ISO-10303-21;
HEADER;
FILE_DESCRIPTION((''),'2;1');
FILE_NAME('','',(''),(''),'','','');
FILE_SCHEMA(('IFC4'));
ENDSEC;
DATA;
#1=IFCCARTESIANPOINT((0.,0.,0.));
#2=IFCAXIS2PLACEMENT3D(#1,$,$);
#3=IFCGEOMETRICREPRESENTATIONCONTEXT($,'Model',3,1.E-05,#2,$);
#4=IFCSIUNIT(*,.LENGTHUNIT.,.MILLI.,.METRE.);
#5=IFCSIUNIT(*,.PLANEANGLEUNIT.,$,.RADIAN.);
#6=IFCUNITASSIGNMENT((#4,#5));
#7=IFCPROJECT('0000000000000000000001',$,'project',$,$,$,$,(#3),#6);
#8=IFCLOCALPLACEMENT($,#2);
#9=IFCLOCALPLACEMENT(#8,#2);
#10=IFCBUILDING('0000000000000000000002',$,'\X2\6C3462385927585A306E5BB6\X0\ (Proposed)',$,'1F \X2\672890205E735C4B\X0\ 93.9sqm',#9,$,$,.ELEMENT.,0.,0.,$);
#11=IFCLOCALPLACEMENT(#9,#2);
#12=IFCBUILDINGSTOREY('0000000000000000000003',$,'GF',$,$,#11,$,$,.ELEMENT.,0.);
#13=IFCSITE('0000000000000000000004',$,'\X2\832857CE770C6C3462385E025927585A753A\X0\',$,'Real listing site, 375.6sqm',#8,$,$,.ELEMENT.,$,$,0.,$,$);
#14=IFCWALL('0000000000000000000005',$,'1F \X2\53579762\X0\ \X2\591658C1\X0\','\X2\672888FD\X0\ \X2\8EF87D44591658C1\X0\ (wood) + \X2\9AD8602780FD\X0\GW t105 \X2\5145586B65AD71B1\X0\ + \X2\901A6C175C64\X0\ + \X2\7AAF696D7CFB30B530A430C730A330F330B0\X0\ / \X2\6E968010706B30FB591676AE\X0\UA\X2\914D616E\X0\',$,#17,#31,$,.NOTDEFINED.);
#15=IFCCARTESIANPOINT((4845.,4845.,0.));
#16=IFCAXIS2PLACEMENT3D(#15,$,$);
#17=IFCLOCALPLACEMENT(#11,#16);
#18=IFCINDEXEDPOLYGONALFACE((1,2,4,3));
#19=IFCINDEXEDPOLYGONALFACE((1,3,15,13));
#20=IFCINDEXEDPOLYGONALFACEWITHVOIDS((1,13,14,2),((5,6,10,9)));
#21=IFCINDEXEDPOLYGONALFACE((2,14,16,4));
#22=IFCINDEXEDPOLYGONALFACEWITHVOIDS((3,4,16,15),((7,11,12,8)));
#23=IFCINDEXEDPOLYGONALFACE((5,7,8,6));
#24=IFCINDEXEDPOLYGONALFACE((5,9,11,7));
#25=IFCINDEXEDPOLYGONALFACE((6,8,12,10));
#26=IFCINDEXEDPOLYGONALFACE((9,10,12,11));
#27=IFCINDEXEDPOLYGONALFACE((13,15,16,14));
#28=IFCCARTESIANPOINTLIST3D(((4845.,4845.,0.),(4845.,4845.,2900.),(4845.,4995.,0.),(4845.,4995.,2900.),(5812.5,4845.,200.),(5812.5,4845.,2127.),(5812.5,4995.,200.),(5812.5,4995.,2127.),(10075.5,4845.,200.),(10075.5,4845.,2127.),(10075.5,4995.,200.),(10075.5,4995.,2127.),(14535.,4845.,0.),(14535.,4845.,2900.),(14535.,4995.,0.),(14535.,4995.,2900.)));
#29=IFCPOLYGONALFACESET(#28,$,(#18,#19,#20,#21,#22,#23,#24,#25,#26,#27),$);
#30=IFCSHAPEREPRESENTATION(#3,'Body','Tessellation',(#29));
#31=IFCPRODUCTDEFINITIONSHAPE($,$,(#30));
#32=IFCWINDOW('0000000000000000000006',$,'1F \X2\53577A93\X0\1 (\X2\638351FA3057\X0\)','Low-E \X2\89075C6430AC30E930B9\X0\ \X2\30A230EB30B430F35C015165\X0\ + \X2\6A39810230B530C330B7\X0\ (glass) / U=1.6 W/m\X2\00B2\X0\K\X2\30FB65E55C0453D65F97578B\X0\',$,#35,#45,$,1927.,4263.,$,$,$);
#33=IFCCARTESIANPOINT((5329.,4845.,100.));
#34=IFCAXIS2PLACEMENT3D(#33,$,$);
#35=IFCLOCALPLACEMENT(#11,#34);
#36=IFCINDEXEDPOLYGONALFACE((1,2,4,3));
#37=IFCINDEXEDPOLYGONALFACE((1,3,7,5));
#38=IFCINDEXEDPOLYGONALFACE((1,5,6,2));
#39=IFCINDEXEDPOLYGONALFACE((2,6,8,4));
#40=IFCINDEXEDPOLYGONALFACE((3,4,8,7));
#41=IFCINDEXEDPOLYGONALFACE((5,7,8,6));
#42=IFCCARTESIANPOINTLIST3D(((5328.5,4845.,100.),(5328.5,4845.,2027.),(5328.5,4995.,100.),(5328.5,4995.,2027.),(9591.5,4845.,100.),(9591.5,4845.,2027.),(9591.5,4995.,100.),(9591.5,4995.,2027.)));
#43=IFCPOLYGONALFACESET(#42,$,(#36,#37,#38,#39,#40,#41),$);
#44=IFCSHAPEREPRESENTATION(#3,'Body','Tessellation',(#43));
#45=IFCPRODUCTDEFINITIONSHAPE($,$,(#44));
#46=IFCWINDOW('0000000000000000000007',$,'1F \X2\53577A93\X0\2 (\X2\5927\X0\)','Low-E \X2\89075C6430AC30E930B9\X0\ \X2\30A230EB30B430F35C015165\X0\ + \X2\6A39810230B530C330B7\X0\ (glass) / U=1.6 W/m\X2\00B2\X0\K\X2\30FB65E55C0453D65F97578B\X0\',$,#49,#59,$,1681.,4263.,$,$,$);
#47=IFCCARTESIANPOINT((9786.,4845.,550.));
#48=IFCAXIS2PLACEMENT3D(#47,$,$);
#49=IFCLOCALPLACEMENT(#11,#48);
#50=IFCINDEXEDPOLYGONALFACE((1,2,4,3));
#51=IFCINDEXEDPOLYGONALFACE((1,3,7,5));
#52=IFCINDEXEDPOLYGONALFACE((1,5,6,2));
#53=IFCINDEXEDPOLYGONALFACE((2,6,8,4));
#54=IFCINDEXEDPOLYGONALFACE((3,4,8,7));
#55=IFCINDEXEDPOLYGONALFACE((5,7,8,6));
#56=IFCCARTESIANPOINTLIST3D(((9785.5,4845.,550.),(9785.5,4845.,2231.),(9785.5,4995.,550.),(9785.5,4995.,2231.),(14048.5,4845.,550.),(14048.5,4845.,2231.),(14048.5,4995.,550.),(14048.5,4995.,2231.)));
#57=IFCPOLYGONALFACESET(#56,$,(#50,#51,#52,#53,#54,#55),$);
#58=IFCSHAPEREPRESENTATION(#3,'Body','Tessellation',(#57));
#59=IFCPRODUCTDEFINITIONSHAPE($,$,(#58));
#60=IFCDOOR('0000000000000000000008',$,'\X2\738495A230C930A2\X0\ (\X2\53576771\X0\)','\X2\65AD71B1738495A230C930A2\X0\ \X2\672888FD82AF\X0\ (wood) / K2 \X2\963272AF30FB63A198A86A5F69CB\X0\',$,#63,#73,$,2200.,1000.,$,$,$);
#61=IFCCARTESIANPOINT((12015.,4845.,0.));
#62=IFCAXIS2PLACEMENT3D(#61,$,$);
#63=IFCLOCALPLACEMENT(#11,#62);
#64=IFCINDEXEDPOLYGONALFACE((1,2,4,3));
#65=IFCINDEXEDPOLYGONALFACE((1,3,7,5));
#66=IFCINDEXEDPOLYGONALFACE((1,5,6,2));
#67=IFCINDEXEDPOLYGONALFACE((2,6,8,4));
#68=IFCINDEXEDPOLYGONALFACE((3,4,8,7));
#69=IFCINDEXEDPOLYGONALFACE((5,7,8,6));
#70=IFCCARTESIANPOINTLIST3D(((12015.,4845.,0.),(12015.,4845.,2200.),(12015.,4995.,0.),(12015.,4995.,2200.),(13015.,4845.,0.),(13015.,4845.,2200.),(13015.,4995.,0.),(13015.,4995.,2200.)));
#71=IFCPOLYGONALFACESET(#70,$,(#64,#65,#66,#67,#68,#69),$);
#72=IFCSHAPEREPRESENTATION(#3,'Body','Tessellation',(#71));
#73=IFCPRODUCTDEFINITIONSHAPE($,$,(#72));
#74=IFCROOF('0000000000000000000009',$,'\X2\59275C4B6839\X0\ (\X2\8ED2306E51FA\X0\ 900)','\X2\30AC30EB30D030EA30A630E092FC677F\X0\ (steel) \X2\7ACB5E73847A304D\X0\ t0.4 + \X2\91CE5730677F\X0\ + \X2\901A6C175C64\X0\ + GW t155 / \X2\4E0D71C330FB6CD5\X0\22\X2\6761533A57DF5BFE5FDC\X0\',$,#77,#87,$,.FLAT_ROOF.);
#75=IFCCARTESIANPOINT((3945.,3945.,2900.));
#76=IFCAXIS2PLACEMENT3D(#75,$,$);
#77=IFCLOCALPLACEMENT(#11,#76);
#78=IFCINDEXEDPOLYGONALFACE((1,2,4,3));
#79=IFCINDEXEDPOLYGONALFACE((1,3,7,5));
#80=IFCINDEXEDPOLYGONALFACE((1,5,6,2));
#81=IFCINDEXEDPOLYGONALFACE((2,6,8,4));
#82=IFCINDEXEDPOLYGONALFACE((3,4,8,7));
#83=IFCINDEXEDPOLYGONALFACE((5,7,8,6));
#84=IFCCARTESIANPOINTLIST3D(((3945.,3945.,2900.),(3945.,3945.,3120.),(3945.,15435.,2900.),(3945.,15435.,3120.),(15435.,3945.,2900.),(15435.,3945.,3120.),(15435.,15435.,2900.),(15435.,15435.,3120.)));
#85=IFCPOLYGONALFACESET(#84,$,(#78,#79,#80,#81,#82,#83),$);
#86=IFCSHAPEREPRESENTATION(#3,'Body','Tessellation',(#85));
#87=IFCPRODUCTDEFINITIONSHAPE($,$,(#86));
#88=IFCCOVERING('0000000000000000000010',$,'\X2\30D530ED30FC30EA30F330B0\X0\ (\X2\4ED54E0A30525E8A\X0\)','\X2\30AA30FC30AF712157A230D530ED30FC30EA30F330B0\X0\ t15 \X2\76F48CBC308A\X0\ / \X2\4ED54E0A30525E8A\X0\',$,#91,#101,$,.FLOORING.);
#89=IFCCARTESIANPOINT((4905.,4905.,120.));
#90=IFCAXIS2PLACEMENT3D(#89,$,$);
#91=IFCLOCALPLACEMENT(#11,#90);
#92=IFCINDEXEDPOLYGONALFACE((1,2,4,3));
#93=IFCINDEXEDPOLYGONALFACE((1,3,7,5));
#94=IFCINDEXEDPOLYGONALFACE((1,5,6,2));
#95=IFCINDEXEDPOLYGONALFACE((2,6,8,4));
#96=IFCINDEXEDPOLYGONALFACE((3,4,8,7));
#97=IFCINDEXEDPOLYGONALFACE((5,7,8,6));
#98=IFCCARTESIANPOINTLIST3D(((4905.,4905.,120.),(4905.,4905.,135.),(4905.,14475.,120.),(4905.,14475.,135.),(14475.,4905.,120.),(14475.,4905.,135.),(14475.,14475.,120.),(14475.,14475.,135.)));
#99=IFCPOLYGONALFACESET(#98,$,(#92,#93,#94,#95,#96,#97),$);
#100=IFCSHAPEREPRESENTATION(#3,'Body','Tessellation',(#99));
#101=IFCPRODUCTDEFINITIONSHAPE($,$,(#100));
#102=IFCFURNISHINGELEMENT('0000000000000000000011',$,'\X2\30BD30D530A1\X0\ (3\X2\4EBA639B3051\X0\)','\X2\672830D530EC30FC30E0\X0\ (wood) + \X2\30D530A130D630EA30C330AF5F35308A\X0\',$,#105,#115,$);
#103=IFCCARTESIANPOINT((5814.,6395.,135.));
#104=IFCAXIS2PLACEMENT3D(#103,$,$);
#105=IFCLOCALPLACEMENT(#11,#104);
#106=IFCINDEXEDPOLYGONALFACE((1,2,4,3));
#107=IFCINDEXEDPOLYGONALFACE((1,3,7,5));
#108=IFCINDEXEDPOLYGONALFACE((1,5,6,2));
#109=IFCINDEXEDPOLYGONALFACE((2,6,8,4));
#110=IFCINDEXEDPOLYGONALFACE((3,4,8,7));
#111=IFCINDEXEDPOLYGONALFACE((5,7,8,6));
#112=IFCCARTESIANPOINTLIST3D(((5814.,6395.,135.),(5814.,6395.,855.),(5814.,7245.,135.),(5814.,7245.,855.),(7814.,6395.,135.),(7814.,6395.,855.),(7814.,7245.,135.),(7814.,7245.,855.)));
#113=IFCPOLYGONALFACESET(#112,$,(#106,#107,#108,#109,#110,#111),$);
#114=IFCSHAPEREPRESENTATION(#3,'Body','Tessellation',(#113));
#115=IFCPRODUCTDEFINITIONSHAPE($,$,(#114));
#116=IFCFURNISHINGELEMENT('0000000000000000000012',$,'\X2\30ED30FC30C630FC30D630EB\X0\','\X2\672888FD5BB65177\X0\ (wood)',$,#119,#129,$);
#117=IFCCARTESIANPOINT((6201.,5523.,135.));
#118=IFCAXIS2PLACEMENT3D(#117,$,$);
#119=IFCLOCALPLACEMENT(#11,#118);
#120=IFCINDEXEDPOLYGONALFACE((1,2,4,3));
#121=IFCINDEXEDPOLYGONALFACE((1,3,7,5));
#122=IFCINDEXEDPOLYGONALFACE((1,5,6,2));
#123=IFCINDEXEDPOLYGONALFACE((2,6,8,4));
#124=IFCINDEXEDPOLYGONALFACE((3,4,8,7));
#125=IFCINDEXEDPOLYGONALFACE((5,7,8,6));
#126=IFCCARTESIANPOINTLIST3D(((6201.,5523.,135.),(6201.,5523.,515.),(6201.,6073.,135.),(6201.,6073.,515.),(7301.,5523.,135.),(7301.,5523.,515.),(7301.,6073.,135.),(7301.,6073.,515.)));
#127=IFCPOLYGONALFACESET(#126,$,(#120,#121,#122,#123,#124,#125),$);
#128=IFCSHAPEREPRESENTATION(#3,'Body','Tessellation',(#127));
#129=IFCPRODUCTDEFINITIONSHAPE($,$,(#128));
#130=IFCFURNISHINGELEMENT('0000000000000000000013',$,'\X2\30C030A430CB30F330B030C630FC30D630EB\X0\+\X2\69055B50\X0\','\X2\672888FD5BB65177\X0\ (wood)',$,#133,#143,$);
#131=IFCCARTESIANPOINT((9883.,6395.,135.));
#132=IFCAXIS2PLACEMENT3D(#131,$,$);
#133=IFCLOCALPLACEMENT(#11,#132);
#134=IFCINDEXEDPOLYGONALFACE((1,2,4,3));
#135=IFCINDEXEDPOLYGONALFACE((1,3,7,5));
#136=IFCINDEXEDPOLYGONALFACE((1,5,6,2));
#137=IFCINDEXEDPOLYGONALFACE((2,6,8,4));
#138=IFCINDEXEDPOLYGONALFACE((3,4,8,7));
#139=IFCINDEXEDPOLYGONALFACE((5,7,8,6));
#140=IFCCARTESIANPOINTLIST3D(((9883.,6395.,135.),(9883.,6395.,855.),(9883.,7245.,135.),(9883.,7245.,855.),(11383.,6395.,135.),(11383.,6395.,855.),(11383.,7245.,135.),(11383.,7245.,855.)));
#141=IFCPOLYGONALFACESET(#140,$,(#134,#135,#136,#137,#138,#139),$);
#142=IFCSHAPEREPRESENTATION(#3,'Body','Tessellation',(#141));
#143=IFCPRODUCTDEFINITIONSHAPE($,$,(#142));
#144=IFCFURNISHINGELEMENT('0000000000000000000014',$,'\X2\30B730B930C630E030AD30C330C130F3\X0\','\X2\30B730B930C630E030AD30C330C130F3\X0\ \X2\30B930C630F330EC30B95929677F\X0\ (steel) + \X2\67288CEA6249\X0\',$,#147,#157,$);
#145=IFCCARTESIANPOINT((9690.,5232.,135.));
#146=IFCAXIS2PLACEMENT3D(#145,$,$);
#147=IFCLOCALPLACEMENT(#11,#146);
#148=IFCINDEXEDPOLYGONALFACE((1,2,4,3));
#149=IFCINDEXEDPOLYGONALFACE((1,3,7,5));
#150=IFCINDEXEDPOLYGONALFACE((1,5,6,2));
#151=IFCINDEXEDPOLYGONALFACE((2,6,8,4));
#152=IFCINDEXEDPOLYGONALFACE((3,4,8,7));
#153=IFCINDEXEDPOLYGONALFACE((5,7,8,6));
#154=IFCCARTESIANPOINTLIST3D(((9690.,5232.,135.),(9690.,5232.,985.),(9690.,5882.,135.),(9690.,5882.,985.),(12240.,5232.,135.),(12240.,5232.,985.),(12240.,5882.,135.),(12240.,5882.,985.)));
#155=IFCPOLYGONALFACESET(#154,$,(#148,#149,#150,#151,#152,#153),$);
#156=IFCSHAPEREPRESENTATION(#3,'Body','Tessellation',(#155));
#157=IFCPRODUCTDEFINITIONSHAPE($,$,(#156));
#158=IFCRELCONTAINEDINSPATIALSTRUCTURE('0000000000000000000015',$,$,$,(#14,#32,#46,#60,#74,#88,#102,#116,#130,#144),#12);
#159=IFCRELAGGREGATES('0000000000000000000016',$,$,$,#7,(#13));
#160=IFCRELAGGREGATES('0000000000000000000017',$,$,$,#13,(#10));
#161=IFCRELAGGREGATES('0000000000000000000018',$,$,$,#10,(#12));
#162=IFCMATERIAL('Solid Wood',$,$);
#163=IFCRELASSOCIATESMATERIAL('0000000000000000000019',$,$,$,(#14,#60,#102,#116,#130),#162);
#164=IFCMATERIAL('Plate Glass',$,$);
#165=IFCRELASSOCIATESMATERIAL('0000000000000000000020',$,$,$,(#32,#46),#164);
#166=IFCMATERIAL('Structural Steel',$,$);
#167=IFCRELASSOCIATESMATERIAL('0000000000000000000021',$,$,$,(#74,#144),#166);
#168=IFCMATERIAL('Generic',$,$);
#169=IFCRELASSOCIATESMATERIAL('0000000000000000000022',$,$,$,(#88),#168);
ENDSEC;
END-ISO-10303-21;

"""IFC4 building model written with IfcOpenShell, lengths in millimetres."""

from ifc_helpers import new_model, si_unit, frame, frame_2d, origin, place, context, project, spatial, rectangle, extrude, material, element, fill, save


model = new_model("IFC4")

# Units and contexts
model_context = context("Model", 3, precision=1e-05, world=origin())
ifc_project = project(units=[si_unit("LENGTHUNIT", "METRE", prefix="MILLI"), si_unit("PLANEANGLEUNIT", "RADIAN")], contexts=[model_context])

# Site, building, storey
site_placement = place(None, origin())
site = spatial("IfcSite", under=ifc_project, at=site_placement, Name="茨城県水戸市大塚町", ObjectType="Real listing site, 375.6sqm", CompositionType="ELEMENT", RefElevation=0.0)
building_placement = place(site_placement, origin())
building = spatial("IfcBuilding", under=site, at=building_placement, Name="水戸大塚の家 (Proposed)", ObjectType="1F 木造平屋 93.9sqm", CompositionType="ELEMENT", ElevationOfRefHeight=0.0, ElevationOfTerrain=0.0)
storey_placement = place(building_placement, origin())
storey = spatial("IfcBuildingStorey", under=building, at=storey_placement, Name="GF", CompositionType="ELEMENT", Elevation=0.0)

# Shared definitions
ifc_material_1 = material(Name="Solid Wood")

# Wall, openings, windows, door
wall_1_placement = place(storey_placement, frame((4845.0, 4845.0, 0.0)))
wall_1 = element("IfcWall", 1, at=wall_1_placement, inside=storey, material=ifc_material_1, Name="1F 南面 外壁", Description="木製 軸組外壁 (wood) + 高性能GW t105 充填断熱 + 通気層 + 窯業系サイディング / 準耐火・外皮UA配慮", PredefinedType="NOTDEFINED", context=model_context, shape_type="SweptSolid", body=[
    extrude(rectangle(XDim=9690.0, YDim=150.0, at=frame_2d((4845.0, 75.0))), frame((4845.0, 4845.0, 0.0)), (0.0, 0.0, 1.0), 2900.0),
])
opening_1_placement = place(storey_placement, frame((5329.0, 4845.0, 100.0)))
opening_1 = element("IfcOpeningElement", 2, at=opening_1_placement, cuts=wall_1, PredefinedType="NOTDEFINED", context=model_context, shape_type="SweptSolid", body=[
    extrude(rectangle(XDim=4263.0, YDim=150.0, at=frame_2d((2131.0, 75.0))), frame((5329.0, 4845.0, 100.0)), (0.0, 0.0, 1.0), 1927.0),
])
opening_2_placement = place(storey_placement, frame((9786.0, 4845.0, 550.0)))
opening_2 = element("IfcOpeningElement", 3, at=opening_2_placement, cuts=wall_1, PredefinedType="NOTDEFINED", context=model_context, shape_type="SweptSolid", body=[
    extrude(rectangle(XDim=4263.0, YDim=150.0, at=frame_2d((2131.0, 75.0))), frame((9786.0, 4845.0, 550.0)), (0.0, 0.0, 1.0), 1681.0),
])
opening_3_placement = place(storey_placement, frame((12015.0, 4845.0, 0.0)))
opening_3 = element("IfcOpeningElement", 4, at=opening_3_placement, cuts=wall_1, PredefinedType="NOTDEFINED", context=model_context, shape_type="SweptSolid", body=[
    extrude(rectangle(XDim=1000.0, YDim=150.0, at=frame_2d((500.0, 75.0))), frame((12015.0, 4845.0, 0.0)), (0.0, 0.0, 1.0), 2200.0),
])
ifc_material_2 = material(Name="Plate Glass")
window_1_placement = place(storey_placement, frame((5329.0, 4845.0, 100.0)))
window_1 = element("IfcWindow", 5, at=window_1_placement, inside=storey, material=ifc_material_2, Name="1F 南窓1 (掃出し)", Description="Low-E 複層ガラス アルゴン封入 + 樹脂サッシ (glass) / U=1.6 W/m²K・日射取得型", OverallHeight=1927.0, OverallWidth=4263.0, context=model_context, shape_type="SweptSolid", body=[
    extrude(rectangle(XDim=4263.0, YDim=150.0, at=frame_2d((2131.0, 75.0))), frame((5329.0, 4845.0, 100.0)), (0.0, 0.0, 1.0), 1927.0),
])
fill(opening_1, window_1)
window_2_placement = place(storey_placement, frame((9786.0, 4845.0, 550.0)))
window_2 = element("IfcWindow", 6, at=window_2_placement, inside=storey, material=ifc_material_2, Name="1F 南窓2 (大)", Description="Low-E 複層ガラス アルゴン封入 + 樹脂サッシ (glass) / U=1.6 W/m²K・日射取得型", OverallHeight=1681.0, OverallWidth=4263.0, context=model_context, shape_type="SweptSolid", body=[
    extrude(rectangle(XDim=4263.0, YDim=150.0, at=frame_2d((2131.0, 75.0))), frame((9786.0, 4845.0, 550.0)), (0.0, 0.0, 1.0), 1681.0),
])
fill(opening_2, window_2)
door_placement = place(storey_placement, frame((12015.0, 4845.0, 0.0)))
door = element("IfcDoor", 7, at=door_placement, inside=storey, material=ifc_material_1, Name="玄関ドア (南東)", Description="断熱玄関ドア 木製芯 (wood) / K2 防犯・採風機構", OverallHeight=2200.0, OverallWidth=1000.0, context=model_context, shape_type="SweptSolid", body=[
    extrude(rectangle(XDim=1000.0, YDim=150.0, at=frame_2d((500.0, 75.0))), frame((12015.0, 4845.0, 0.0)), (0.0, 0.0, 1.0), 2200.0),
])
fill(opening_3, door)

# Roof
ifc_material_3 = material(Name="Structural Steel")
roof_placement = place(storey_placement, frame((3945.0, 3945.0, 2900.0)))
element("IfcRoof", 8, at=roof_placement, inside=storey, material=ifc_material_3, Name="大屋根 (軒の出 900)", Description="ガルバリウム鋼板 (steel) 立平葺き t0.4 + 野地板 + 通気層 + GW t155 / 不燃・法22条区域対応", PredefinedType="FLAT_ROOF", context=model_context, shape_type="SweptSolid", body=[
    extrude(rectangle(XDim=11490.0, YDim=11490.0, at=frame_2d((5745.0, 5745.0))), frame((3945.0, 3945.0, 2900.0)), (0.0, 0.0, 1.0), 220.0),
])

# Covering
ifc_material_4 = material(Name="Generic")
covering_placement = place(storey_placement, frame((4905.0, 4905.0, 120.0)))
element("IfcCovering", 9, at=covering_placement, inside=storey, material=ifc_material_4, Name="フローリング (仕上げ床)", Description="オーク無垢フローリング t15 直貼り / 仕上げ床", PredefinedType="FLOORING", context=model_context, shape_type="SweptSolid", body=[
    extrude(rectangle(XDim=9570.0, YDim=9570.0, at=frame_2d((4785.0, 4785.0))), frame((4905.0, 4905.0, 120.0)), (0.0, 0.0, 1.0), 15.0),
])

# Furnishing elements
furnishing_1_placement = place(storey_placement, frame((5814.0, 6395.0, 135.0)))
element("IfcFurnishingElement", 10, at=furnishing_1_placement, inside=storey, material=ifc_material_1, Name="ソファ (3人掛け)", Description="木フレーム (wood) + ファブリック張り", context=model_context, shape_type="SweptSolid", body=[
    extrude(rectangle(XDim=2000.0, YDim=850.0, at=frame_2d((1000.0, 425.0))), frame((5814.0, 6395.0, 135.0)), (0.0, 0.0, 1.0), 720.0),
])
furnishing_2_placement = place(storey_placement, frame((6201.0, 5523.0, 135.0)))
element("IfcFurnishingElement", 11, at=furnishing_2_placement, inside=storey, material=ifc_material_1, Name="ローテーブル", Description="木製家具 (wood)", context=model_context, shape_type="SweptSolid", body=[
    extrude(rectangle(XDim=1100.0, YDim=550.0, at=frame_2d((550.0, 275.0))), frame((6201.0, 5523.0, 135.0)), (0.0, 0.0, 1.0), 380.0),
])
furnishing_3_placement = place(storey_placement, frame((9883.0, 6395.0, 135.0)))
element("IfcFurnishingElement", 12, at=furnishing_3_placement, inside=storey, material=ifc_material_1, Name="ダイニングテーブル+椅子", Description="木製家具 (wood)", context=model_context, shape_type="SweptSolid", body=[
    extrude(rectangle(XDim=1500.0, YDim=850.0, at=frame_2d((750.0, 425.0))), frame((9883.0, 6395.0, 135.0)), (0.0, 0.0, 1.0), 720.0),
])
furnishing_4_placement = place(storey_placement, frame((9690.0, 5232.0, 135.0)))
element("IfcFurnishingElement", 13, at=furnishing_4_placement, inside=storey, material=ifc_material_3, Name="システムキッチン", Description="システムキッチン ステンレス天板 (steel) + 木質扉", context=model_context, shape_type="SweptSolid", body=[
    extrude(rectangle(XDim=2550.0, YDim=650.0, at=frame_2d((1275.0, 325.0))), frame((9690.0, 5232.0, 135.0)), (0.0, 0.0, 1.0), 850.0),
])

save(model, "model.ifc")
